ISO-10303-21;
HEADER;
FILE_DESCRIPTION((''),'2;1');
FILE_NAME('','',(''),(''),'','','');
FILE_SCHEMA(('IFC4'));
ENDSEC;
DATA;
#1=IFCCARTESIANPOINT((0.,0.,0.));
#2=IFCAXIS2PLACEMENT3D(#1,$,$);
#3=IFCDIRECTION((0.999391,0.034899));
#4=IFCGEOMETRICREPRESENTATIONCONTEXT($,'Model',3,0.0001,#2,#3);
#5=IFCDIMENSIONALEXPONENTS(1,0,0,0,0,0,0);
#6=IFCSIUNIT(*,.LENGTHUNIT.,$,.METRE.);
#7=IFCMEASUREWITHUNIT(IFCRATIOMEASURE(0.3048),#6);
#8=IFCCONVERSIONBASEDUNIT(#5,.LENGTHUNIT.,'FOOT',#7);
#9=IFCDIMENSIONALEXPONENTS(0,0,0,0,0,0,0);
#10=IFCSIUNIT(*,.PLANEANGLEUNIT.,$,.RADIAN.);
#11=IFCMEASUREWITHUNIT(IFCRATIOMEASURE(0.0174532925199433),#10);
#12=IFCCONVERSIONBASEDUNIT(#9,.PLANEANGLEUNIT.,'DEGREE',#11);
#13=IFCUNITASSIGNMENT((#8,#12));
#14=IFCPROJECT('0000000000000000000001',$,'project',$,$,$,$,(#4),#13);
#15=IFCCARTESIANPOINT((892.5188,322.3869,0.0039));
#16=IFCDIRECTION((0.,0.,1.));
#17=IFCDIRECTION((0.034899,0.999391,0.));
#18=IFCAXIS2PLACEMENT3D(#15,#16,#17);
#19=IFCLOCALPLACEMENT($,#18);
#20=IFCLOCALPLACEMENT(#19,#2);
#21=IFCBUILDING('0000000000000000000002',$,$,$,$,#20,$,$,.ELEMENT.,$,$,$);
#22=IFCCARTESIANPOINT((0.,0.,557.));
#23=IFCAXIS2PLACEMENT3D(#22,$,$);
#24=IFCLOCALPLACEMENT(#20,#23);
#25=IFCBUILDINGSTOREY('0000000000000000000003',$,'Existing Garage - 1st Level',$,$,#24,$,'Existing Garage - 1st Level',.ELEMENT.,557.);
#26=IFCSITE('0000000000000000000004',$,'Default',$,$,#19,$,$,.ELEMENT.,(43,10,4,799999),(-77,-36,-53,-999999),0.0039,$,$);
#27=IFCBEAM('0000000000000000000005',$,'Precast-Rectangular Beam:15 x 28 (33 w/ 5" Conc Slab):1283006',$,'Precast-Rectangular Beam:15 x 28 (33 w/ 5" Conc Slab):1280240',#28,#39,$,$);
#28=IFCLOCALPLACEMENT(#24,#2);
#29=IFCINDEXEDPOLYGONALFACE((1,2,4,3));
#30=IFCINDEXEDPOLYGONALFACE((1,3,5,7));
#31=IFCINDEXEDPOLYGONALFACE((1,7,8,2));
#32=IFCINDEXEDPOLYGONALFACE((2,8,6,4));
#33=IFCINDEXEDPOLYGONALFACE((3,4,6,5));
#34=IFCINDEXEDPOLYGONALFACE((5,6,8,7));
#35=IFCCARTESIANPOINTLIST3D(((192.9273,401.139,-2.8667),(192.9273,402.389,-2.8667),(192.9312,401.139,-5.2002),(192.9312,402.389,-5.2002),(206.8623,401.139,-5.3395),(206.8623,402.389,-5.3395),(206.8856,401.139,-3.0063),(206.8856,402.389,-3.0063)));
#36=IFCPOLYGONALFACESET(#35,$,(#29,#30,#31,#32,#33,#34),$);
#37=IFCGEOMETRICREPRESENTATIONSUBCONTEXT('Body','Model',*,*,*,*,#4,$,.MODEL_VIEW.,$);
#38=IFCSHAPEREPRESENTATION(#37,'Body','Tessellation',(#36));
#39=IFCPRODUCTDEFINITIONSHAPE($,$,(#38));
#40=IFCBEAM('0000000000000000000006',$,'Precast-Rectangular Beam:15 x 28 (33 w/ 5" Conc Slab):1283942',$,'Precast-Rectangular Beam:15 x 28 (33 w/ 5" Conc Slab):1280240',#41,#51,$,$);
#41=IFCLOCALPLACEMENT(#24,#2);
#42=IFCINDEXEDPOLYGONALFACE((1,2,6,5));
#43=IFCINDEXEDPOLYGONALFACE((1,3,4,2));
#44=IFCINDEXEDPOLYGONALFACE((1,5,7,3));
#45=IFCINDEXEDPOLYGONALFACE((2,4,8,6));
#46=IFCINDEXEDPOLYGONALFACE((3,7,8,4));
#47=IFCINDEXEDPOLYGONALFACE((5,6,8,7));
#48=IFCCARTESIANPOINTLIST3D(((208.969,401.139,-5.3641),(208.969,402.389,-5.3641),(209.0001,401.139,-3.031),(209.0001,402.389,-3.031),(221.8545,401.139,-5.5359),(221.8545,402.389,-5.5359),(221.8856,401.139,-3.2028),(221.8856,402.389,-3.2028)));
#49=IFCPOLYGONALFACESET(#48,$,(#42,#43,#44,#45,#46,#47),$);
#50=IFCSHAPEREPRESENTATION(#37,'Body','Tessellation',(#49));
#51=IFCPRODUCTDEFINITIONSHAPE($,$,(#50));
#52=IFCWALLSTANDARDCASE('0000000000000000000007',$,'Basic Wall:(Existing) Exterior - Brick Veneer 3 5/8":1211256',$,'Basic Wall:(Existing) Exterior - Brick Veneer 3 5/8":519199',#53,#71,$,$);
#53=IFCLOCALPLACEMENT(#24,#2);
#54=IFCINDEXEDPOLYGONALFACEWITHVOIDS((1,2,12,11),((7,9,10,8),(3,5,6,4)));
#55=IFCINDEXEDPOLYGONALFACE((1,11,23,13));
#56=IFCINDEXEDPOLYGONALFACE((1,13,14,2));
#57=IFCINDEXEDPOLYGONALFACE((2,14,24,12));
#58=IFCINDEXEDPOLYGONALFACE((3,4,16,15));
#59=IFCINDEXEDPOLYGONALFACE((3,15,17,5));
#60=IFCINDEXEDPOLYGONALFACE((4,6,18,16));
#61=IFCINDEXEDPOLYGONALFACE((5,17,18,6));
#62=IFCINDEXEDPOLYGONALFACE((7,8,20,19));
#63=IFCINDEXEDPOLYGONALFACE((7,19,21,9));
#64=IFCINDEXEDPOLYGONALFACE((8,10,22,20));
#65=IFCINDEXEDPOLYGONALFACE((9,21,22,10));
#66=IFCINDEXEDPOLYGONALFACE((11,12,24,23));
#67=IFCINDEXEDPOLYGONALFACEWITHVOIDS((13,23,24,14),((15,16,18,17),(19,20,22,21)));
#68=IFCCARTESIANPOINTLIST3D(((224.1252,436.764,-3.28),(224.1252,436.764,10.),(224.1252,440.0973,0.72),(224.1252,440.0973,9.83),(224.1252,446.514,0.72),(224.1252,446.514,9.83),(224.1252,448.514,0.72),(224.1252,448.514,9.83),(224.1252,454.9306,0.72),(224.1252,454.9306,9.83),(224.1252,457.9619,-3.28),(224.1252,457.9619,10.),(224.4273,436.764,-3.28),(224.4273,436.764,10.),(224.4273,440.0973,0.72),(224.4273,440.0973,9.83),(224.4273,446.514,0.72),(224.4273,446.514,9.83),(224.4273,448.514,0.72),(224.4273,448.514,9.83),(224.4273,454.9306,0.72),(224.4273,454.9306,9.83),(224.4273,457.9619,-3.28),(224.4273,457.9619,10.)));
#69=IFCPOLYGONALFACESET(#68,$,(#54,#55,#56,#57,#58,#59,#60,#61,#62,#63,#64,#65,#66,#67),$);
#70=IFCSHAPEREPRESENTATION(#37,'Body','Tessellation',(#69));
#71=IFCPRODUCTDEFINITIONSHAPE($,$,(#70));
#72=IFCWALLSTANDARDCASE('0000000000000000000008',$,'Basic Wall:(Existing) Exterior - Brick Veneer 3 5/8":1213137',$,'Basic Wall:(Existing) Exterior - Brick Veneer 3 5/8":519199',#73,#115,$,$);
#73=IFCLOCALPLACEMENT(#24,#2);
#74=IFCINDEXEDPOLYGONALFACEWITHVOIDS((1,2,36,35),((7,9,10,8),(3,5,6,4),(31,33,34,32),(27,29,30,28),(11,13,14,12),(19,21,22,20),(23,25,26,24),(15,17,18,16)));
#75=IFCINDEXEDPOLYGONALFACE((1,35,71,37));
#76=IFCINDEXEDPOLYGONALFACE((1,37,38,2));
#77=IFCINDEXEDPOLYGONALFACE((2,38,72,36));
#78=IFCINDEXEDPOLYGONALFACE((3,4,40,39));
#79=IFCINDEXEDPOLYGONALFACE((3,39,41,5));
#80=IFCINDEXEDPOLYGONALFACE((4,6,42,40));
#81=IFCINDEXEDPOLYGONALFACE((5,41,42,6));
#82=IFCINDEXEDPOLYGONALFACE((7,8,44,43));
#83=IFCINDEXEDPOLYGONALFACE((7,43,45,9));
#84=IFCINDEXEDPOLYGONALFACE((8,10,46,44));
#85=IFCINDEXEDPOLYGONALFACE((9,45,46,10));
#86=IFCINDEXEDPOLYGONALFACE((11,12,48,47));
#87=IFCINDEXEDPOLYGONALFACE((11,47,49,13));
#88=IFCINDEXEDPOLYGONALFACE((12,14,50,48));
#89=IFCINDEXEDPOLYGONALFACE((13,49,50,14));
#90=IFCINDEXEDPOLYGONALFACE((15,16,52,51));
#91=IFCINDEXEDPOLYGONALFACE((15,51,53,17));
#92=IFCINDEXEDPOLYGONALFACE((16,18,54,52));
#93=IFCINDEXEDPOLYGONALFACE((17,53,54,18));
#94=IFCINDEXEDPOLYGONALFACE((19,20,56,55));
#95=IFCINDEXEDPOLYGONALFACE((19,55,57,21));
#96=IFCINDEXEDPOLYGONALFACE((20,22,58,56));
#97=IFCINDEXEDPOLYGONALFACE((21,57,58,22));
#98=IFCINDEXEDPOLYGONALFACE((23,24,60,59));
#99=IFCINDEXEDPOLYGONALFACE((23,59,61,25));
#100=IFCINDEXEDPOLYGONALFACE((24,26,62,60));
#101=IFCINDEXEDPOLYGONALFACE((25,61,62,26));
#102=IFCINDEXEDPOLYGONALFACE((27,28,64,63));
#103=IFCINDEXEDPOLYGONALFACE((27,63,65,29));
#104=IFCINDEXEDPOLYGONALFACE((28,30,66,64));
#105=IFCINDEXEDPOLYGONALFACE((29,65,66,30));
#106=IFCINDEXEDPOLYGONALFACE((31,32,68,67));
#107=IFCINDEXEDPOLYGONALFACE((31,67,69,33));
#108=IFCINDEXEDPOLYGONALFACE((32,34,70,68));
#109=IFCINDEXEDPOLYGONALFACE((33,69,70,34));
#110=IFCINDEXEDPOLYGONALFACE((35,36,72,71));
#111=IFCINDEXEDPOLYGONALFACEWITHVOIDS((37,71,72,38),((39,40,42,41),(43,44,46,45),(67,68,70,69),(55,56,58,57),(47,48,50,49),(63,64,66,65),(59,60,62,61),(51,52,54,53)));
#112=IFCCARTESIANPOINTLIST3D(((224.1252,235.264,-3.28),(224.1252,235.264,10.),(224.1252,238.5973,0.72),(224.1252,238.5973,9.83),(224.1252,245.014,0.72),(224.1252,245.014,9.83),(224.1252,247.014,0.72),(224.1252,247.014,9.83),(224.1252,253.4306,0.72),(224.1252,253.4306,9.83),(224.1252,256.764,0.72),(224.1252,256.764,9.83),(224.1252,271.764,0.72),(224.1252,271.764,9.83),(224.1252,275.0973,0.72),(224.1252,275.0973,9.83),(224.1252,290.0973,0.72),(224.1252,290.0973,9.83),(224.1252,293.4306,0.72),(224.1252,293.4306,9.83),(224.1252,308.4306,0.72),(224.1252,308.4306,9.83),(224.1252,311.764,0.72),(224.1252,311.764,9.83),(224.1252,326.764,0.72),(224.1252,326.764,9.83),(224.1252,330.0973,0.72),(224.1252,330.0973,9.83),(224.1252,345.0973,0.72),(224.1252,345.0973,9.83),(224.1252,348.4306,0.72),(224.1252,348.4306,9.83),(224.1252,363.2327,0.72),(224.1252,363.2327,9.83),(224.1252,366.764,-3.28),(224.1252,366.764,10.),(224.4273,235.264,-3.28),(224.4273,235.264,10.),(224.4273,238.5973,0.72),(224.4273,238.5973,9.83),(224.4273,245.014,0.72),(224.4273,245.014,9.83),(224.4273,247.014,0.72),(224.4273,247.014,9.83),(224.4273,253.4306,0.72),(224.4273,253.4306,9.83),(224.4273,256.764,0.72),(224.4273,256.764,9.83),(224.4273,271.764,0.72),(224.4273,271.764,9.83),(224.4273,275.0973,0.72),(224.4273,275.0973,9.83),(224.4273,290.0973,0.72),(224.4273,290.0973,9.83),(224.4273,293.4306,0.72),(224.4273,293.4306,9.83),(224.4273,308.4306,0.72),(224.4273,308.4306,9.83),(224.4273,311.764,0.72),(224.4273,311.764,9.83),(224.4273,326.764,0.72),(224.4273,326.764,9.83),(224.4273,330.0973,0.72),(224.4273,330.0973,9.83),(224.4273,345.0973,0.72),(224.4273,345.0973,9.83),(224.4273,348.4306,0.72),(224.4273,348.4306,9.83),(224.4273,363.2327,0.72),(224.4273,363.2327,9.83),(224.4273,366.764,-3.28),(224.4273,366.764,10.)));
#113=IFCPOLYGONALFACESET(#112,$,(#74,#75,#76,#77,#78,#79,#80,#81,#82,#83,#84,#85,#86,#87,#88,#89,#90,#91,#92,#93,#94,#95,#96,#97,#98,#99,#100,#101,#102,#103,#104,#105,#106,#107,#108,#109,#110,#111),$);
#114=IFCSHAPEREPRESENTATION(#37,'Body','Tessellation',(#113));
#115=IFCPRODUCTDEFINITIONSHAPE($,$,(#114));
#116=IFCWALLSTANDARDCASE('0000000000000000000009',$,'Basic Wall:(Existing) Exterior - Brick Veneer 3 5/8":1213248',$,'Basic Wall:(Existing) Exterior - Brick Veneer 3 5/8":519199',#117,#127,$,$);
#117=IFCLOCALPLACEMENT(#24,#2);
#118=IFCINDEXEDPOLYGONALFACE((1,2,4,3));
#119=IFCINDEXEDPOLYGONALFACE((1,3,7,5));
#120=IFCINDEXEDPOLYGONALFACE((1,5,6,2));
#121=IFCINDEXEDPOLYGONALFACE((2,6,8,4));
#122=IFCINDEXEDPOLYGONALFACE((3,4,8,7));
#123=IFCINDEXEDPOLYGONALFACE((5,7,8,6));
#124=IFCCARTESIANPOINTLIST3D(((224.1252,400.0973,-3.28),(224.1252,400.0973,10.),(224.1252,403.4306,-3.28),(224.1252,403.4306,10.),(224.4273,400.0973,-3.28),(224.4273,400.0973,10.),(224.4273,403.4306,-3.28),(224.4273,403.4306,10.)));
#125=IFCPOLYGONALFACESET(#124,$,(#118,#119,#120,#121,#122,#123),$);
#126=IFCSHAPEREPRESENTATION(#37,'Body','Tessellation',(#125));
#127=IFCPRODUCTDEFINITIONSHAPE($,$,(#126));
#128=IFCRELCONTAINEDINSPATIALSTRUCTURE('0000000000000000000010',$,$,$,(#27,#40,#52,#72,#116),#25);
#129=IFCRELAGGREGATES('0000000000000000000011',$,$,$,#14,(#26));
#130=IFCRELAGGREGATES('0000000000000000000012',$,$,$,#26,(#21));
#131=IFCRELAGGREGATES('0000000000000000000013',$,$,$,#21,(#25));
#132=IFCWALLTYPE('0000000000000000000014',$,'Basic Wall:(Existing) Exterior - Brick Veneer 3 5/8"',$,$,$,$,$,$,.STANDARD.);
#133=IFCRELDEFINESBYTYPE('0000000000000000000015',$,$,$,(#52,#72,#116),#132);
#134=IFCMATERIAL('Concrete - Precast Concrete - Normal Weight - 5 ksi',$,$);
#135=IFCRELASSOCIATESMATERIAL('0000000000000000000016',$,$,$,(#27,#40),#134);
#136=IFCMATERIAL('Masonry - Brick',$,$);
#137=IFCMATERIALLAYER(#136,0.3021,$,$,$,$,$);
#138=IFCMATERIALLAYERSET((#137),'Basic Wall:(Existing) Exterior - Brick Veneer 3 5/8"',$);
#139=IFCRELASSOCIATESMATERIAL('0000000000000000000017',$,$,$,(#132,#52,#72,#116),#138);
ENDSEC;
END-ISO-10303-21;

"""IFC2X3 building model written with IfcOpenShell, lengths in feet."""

from ifc_helpers import new_model, entity, si_unit, converted_unit, direction, frame, frame_2d, origin, origin_2d_with_axis, place, context, subcontext, project, spatial, rectangle, extrude, clip, halfspace, material, layer, layer_set, layer_usage, type_object, element, save


model = new_model("IFC2X3")

# Units and contexts
model_context = context("Model", 3, precision=0.0001, world=origin(), true_north=direction((0.999391, 0.034899)))
body_context = subcontext(model_context, "Body", "Model", "MODEL_VIEW")
ifc_project = project(units=[converted_unit("LENGTHUNIT", "FOOT", entity("IfcRatioMeasure", 0.3048), si_unit("LENGTHUNIT", "METRE"), dimensions=[1, 0, 0, 0, 0, 0, 0]), converted_unit("PLANEANGLEUNIT", "DEGREE", entity("IfcRatioMeasure", 0.0174532925199433), si_unit("PLANEANGLEUNIT", "RADIAN"), dimensions=[0, 0, 0, 0, 0, 0, 0])], contexts=[model_context])

# Site, building, storey
site_placement = place(None, frame((892.5188, 322.3869, 0.0039), z_axis=(0.0, 0.0, 1.0), x_axis=(0.034899, 0.999391, 0.0)))
site = spatial("IfcSite", under=ifc_project, at=site_placement, Name="Default", CompositionType="ELEMENT", RefLatitude=(43, 10, 4, 799999), RefLongitude=(-77, -36, -53, -999999), RefElevation=0.0039)
building_placement = place(site_placement, origin())
building = spatial("IfcBuilding", under=site, at=building_placement, CompositionType="ELEMENT")
storey_placement = place(building_placement, frame((0.0, 0.0, 557.0)))
storey = spatial("IfcBuildingStorey", under=building, at=storey_placement, Name="Existing Garage - 1st Level", LongName="Existing Garage - 1st Level", CompositionType="ELEMENT", Elevation=557.0)

# Beams
ifc_material_1 = material(Name="Concrete - Precast Concrete - Normal Weight - 5 ksi")
beam_1_placement = place(storey_placement, frame((192.9273, 401.764, -2.8667), z_axis=(0.01, 0.0, 0.99995), x_axis=(0.99995, 0.0, -0.01)))
element("IfcBeam", 1, at=beam_1_placement, inside=storey, material=ifc_material_1, Name="Precast-Rectangular Beam:15 x 28 (33 w/ 5\" Conc Slab):1283006", ObjectType="Precast-Rectangular Beam:15 x 28 (33 w/ 5\" Conc Slab):1280240", context=body_context, shape_type="Clipping", body=[
    clip(extrude(rectangle(XDim=2.3333, YDim=1.25, at=origin_2d_with_axis()), frame((0.0, 0.0, -1.1667), z_axis=(1.0, 0.0, 0.0), x_axis=(0.0, 0.0, -1.0)), (0.0, 0.0, 1.0), 13.959), halfspace(frame((0.0, 0.0, 0.0), z_axis=(-0.999932, 0.0, -0.011666), x_axis=(0.0, -1.0, 0.0)), False)),
])
beam_2_placement = place(storey_placement, frame((222.9273, 401.764, -3.2167), z_axis=(0.013332, 0.0, 0.999911), x_axis=(-0.999911, 0.0, 0.013332)))
element("IfcBeam", 2, at=beam_2_placement, inside=storey, material=ifc_material_1, Name="Precast-Rectangular Beam:15 x 28 (33 w/ 5\" Conc Slab):1283942", ObjectType="Precast-Rectangular Beam:15 x 28 (33 w/ 5\" Conc Slab):1280240", context=body_context, shape_type="SweptSolid", body=[
    extrude(rectangle(XDim=2.3333, YDim=1.25, at=origin_2d_with_axis()), frame((1.0418, 0.0, -1.1667), z_axis=(1.0, 0.0, 0.0), x_axis=(0.0, 0.0, -1.0)), (0.0, 0.0, 1.0), 12.8867),
])

# Walls, openings
ifc_material_2 = material(Name="Masonry - Brick")
ifc_layer = layer(ifc_material_2, 0.3021)
ifc_layer_set = layer_set([ifc_layer], Name="Basic Wall:(Existing) Exterior - Brick Veneer 3 5/8\"")
ifc_layer_usage_1 = layer_usage(ifc_layer_set, "AXIS2", "NEGATIVE", 0.151)
wall_type = type_object("IfcWallType", Name="Basic Wall:(Existing) Exterior - Brick Veneer 3 5/8\"", PredefinedType="STANDARD", material=ifc_layer_set)
wall_1_placement = place(storey_placement, frame((224.2763, 457.9619, -3.28), z_axis=(0.0, 0.0, 1.0), x_axis=(0.0, -1.0, 0.0)))
wall_1 = element("IfcWallStandardCase", 3, at=wall_1_placement, inside=storey, type_object=wall_type, material=ifc_layer_usage_1, Name="Basic Wall:(Existing) Exterior - Brick Veneer 3 5/8\":1211256", ObjectType="Basic Wall:(Existing) Exterior - Brick Veneer 3 5/8\":519199", context=body_context, shape_type="SweptSolid", body=[
    extrude(rectangle(XDim=21.1979, YDim=0.3021, at=frame_2d((10.599, 0.0), x_axis=(-1.0, 0.0))), origin(), (0.0, 0.0, 1.0), 13.28),
])
opening_1_placement = place(wall_1_placement, origin())
element("IfcOpeningElement", 4, at=opening_1_placement, cuts=wall_1, ObjectType="Opening", context=body_context, shape_type="SweptSolid", body=[
    extrude(rectangle(XDim=9.11, YDim=6.4167, at=frame_2d((0.0, 0.0), x_axis=(0.0, 1.0))), frame((14.6563, 0.151, 8.555), z_axis=(0.0, -1.0, 0.0), x_axis=(1.0, 0.0, 0.0)), (0.0, 0.0, 1.0), 0.3021),
])
opening_2_placement = place(wall_1_placement, origin())
element("IfcOpeningElement", 5, at=opening_2_placement, cuts=wall_1, ObjectType="Opening", context=body_context, shape_type="SweptSolid", body=[
    extrude(rectangle(XDim=9.11, YDim=6.4167, at=origin_2d_with_axis()), frame((6.2396, 0.151, 8.555), z_axis=(0.0, -1.0, 0.0), x_axis=(0.0, 0.0, -1.0)), (0.0, 0.0, 1.0), 0.3021),
])
ifc_layer_usage_2 = layer_usage(ifc_layer_set, "AXIS2", "NEGATIVE", 0.151)
wall_2_placement = place(storey_placement, frame((224.2763, 366.764, -3.28), z_axis=(0.0, 0.0, 1.0), x_axis=(0.0, -1.0, 0.0)))
wall_2 = element("IfcWallStandardCase", 6, at=wall_2_placement, inside=storey, type_object=wall_type, material=ifc_layer_usage_2, Name="Basic Wall:(Existing) Exterior - Brick Veneer 3 5/8\":1213137", ObjectType="Basic Wall:(Existing) Exterior - Brick Veneer 3 5/8\":519199", context=body_context, shape_type="SweptSolid", body=[
    extrude(rectangle(XDim=131.5, YDim=0.3021, at=frame_2d((65.75, 0.0), x_axis=(-1.0, 0.0))), origin(), (0.0, 0.0, 1.0), 13.28),
])
opening_3_placement = place(wall_2_placement, origin())
element("IfcOpeningElement", 7, at=opening_3_placement, cuts=wall_2, ObjectType="Opening", context=body_context, shape_type="SweptSolid", body=[
    extrude(rectangle(XDim=9.11, YDim=6.4167, at=frame_2d((0.0, 0.0), x_axis=(1.0, 0.0))), frame((124.9583, 0.151, 8.555), z_axis=(0.0, -1.0, 0.0), x_axis=(0.0, 0.0, 1.0)), (0.0, 0.0, 1.0), 0.3021),
])
opening_4_placement = place(wall_2_placement, origin())
element("IfcOpeningElement", 8, at=opening_4_placement, cuts=wall_2, ObjectType="Opening", context=body_context, shape_type="SweptSolid", body=[
    extrude(rectangle(XDim=9.11, YDim=6.4167, at=frame_2d((0.0, 0.0), x_axis=(0.0, -1.0))), frame((116.5417, 0.151, 8.555), z_axis=(0.0, 1.0, 0.0), x_axis=(1.0, 0.0, 0.0)), (0.0, 0.0, -1.0), 0.3021),
])
opening_5_placement = place(wall_2_placement, origin())
element("IfcOpeningElement", 9, at=opening_5_placement, cuts=wall_2, ObjectType="Opening", context=body_context, shape_type="SweptSolid", body=[
    extrude(rectangle(XDim=9.11, YDim=15.0, at=frame_2d((0.0, 0.0), x_axis=(1.0, 0.0))), frame((102.5, 0.151, 8.555), z_axis=(0.0, -1.0, 0.0), x_axis=(0.0, 0.0, 1.0)), (0.0, 0.0, 1.0), 0.3021),
])
opening_6_placement = place(wall_2_placement, origin())
element("IfcOpeningElement", 10, at=opening_6_placement, cuts=wall_2, ObjectType="Opening", context=body_context, shape_type="SweptSolid", body=[
    extrude(rectangle(XDim=9.11, YDim=15.0, at=frame_2d((0.0, 0.0), x_axis=(1.0, 0.0))), frame((84.1667, 0.151, 8.555), z_axis=(0.0, -1.0, 0.0), x_axis=(0.0, 0.0, 1.0)), (0.0, 0.0, 1.0), 0.3021),
])
opening_7_placement = place(wall_2_placement, origin())
element("IfcOpeningElement", 11, at=opening_7_placement, cuts=wall_2, ObjectType="Opening", context=body_context, shape_type="SweptSolid", body=[
    extrude(rectangle(XDim=9.11, YDim=15.0, at=frame_2d((0.0, 0.0), x_axis=(1.0, 0.0))), frame((65.8333, 0.151, 8.555), z_axis=(0.0, -1.0, 0.0), x_axis=(0.0, 0.0, 1.0)), (0.0, 0.0, 1.0), 0.3021),
])
opening_8_placement = place(wall_2_placement, origin())
element("IfcOpeningElement", 12, at=opening_8_placement, cuts=wall_2, ObjectType="Opening", context=body_context, shape_type="SweptSolid", body=[
    extrude(rectangle(XDim=9.11, YDim=15.0, at=frame_2d((0.0, 0.0), x_axis=(1.0, 0.0))), frame((47.5, 0.151, 8.555), z_axis=(0.0, -1.0, 0.0), x_axis=(0.0, 0.0, 1.0)), (0.0, 0.0, 1.0), 0.3021),
])
opening_9_placement = place(wall_2_placement, origin())
element("IfcOpeningElement", 13, at=opening_9_placement, cuts=wall_2, ObjectType="Opening", context=body_context, shape_type="SweptSolid", body=[
    extrude(rectangle(XDim=9.11, YDim=15.0, at=frame_2d((0.0, 0.0), x_axis=(0.0, 1.0))), frame((29.1667, 0.151, 8.555), z_axis=(0.0, -1.0, 0.0), x_axis=(1.0, 0.0, 0.0)), (0.0, 0.0, 1.0), 0.3021),
])
opening_10_placement = place(wall_2_placement, origin())
element("IfcOpeningElement", 14, at=opening_10_placement, cuts=wall_2, ObjectType="Opening", context=body_context, shape_type="SweptSolid", body=[
    extrude(rectangle(XDim=9.11, YDim=14.8021, at=frame_2d((0.0, 0.0), x_axis=(0.0, -1.0))), frame((10.9323, 0.151, 8.555), z_axis=(0.0, 1.0, 0.0), x_axis=(-1.0, 0.0, 0.0)), (0.0, 0.0, -1.0), 0.3021),
])

# Wall
ifc_layer_usage_3 = layer_usage(ifc_layer_set, "AXIS2", "NEGATIVE", 0.151)
wall_3_placement = place(storey_placement, frame((224.2763, 403.4306, -3.28), z_axis=(0.0, 0.0, 1.0), x_axis=(0.0, -1.0, 0.0)))
element("IfcWallStandardCase", 15, at=wall_3_placement, inside=storey, type_object=wall_type, material=ifc_layer_usage_3, Name="Basic Wall:(Existing) Exterior - Brick Veneer 3 5/8\":1213248", ObjectType="Basic Wall:(Existing) Exterior - Brick Veneer 3 5/8\":519199", context=body_context, shape_type="SweptSolid", body=[
    extrude(rectangle(XDim=3.3333, YDim=0.3021, at=frame_2d((1.6667, 0.0), x_axis=(-1.0, 0.0))), origin(), (0.0, 0.0, 1.0), 13.28),
])

save(model, "model.ifc")
